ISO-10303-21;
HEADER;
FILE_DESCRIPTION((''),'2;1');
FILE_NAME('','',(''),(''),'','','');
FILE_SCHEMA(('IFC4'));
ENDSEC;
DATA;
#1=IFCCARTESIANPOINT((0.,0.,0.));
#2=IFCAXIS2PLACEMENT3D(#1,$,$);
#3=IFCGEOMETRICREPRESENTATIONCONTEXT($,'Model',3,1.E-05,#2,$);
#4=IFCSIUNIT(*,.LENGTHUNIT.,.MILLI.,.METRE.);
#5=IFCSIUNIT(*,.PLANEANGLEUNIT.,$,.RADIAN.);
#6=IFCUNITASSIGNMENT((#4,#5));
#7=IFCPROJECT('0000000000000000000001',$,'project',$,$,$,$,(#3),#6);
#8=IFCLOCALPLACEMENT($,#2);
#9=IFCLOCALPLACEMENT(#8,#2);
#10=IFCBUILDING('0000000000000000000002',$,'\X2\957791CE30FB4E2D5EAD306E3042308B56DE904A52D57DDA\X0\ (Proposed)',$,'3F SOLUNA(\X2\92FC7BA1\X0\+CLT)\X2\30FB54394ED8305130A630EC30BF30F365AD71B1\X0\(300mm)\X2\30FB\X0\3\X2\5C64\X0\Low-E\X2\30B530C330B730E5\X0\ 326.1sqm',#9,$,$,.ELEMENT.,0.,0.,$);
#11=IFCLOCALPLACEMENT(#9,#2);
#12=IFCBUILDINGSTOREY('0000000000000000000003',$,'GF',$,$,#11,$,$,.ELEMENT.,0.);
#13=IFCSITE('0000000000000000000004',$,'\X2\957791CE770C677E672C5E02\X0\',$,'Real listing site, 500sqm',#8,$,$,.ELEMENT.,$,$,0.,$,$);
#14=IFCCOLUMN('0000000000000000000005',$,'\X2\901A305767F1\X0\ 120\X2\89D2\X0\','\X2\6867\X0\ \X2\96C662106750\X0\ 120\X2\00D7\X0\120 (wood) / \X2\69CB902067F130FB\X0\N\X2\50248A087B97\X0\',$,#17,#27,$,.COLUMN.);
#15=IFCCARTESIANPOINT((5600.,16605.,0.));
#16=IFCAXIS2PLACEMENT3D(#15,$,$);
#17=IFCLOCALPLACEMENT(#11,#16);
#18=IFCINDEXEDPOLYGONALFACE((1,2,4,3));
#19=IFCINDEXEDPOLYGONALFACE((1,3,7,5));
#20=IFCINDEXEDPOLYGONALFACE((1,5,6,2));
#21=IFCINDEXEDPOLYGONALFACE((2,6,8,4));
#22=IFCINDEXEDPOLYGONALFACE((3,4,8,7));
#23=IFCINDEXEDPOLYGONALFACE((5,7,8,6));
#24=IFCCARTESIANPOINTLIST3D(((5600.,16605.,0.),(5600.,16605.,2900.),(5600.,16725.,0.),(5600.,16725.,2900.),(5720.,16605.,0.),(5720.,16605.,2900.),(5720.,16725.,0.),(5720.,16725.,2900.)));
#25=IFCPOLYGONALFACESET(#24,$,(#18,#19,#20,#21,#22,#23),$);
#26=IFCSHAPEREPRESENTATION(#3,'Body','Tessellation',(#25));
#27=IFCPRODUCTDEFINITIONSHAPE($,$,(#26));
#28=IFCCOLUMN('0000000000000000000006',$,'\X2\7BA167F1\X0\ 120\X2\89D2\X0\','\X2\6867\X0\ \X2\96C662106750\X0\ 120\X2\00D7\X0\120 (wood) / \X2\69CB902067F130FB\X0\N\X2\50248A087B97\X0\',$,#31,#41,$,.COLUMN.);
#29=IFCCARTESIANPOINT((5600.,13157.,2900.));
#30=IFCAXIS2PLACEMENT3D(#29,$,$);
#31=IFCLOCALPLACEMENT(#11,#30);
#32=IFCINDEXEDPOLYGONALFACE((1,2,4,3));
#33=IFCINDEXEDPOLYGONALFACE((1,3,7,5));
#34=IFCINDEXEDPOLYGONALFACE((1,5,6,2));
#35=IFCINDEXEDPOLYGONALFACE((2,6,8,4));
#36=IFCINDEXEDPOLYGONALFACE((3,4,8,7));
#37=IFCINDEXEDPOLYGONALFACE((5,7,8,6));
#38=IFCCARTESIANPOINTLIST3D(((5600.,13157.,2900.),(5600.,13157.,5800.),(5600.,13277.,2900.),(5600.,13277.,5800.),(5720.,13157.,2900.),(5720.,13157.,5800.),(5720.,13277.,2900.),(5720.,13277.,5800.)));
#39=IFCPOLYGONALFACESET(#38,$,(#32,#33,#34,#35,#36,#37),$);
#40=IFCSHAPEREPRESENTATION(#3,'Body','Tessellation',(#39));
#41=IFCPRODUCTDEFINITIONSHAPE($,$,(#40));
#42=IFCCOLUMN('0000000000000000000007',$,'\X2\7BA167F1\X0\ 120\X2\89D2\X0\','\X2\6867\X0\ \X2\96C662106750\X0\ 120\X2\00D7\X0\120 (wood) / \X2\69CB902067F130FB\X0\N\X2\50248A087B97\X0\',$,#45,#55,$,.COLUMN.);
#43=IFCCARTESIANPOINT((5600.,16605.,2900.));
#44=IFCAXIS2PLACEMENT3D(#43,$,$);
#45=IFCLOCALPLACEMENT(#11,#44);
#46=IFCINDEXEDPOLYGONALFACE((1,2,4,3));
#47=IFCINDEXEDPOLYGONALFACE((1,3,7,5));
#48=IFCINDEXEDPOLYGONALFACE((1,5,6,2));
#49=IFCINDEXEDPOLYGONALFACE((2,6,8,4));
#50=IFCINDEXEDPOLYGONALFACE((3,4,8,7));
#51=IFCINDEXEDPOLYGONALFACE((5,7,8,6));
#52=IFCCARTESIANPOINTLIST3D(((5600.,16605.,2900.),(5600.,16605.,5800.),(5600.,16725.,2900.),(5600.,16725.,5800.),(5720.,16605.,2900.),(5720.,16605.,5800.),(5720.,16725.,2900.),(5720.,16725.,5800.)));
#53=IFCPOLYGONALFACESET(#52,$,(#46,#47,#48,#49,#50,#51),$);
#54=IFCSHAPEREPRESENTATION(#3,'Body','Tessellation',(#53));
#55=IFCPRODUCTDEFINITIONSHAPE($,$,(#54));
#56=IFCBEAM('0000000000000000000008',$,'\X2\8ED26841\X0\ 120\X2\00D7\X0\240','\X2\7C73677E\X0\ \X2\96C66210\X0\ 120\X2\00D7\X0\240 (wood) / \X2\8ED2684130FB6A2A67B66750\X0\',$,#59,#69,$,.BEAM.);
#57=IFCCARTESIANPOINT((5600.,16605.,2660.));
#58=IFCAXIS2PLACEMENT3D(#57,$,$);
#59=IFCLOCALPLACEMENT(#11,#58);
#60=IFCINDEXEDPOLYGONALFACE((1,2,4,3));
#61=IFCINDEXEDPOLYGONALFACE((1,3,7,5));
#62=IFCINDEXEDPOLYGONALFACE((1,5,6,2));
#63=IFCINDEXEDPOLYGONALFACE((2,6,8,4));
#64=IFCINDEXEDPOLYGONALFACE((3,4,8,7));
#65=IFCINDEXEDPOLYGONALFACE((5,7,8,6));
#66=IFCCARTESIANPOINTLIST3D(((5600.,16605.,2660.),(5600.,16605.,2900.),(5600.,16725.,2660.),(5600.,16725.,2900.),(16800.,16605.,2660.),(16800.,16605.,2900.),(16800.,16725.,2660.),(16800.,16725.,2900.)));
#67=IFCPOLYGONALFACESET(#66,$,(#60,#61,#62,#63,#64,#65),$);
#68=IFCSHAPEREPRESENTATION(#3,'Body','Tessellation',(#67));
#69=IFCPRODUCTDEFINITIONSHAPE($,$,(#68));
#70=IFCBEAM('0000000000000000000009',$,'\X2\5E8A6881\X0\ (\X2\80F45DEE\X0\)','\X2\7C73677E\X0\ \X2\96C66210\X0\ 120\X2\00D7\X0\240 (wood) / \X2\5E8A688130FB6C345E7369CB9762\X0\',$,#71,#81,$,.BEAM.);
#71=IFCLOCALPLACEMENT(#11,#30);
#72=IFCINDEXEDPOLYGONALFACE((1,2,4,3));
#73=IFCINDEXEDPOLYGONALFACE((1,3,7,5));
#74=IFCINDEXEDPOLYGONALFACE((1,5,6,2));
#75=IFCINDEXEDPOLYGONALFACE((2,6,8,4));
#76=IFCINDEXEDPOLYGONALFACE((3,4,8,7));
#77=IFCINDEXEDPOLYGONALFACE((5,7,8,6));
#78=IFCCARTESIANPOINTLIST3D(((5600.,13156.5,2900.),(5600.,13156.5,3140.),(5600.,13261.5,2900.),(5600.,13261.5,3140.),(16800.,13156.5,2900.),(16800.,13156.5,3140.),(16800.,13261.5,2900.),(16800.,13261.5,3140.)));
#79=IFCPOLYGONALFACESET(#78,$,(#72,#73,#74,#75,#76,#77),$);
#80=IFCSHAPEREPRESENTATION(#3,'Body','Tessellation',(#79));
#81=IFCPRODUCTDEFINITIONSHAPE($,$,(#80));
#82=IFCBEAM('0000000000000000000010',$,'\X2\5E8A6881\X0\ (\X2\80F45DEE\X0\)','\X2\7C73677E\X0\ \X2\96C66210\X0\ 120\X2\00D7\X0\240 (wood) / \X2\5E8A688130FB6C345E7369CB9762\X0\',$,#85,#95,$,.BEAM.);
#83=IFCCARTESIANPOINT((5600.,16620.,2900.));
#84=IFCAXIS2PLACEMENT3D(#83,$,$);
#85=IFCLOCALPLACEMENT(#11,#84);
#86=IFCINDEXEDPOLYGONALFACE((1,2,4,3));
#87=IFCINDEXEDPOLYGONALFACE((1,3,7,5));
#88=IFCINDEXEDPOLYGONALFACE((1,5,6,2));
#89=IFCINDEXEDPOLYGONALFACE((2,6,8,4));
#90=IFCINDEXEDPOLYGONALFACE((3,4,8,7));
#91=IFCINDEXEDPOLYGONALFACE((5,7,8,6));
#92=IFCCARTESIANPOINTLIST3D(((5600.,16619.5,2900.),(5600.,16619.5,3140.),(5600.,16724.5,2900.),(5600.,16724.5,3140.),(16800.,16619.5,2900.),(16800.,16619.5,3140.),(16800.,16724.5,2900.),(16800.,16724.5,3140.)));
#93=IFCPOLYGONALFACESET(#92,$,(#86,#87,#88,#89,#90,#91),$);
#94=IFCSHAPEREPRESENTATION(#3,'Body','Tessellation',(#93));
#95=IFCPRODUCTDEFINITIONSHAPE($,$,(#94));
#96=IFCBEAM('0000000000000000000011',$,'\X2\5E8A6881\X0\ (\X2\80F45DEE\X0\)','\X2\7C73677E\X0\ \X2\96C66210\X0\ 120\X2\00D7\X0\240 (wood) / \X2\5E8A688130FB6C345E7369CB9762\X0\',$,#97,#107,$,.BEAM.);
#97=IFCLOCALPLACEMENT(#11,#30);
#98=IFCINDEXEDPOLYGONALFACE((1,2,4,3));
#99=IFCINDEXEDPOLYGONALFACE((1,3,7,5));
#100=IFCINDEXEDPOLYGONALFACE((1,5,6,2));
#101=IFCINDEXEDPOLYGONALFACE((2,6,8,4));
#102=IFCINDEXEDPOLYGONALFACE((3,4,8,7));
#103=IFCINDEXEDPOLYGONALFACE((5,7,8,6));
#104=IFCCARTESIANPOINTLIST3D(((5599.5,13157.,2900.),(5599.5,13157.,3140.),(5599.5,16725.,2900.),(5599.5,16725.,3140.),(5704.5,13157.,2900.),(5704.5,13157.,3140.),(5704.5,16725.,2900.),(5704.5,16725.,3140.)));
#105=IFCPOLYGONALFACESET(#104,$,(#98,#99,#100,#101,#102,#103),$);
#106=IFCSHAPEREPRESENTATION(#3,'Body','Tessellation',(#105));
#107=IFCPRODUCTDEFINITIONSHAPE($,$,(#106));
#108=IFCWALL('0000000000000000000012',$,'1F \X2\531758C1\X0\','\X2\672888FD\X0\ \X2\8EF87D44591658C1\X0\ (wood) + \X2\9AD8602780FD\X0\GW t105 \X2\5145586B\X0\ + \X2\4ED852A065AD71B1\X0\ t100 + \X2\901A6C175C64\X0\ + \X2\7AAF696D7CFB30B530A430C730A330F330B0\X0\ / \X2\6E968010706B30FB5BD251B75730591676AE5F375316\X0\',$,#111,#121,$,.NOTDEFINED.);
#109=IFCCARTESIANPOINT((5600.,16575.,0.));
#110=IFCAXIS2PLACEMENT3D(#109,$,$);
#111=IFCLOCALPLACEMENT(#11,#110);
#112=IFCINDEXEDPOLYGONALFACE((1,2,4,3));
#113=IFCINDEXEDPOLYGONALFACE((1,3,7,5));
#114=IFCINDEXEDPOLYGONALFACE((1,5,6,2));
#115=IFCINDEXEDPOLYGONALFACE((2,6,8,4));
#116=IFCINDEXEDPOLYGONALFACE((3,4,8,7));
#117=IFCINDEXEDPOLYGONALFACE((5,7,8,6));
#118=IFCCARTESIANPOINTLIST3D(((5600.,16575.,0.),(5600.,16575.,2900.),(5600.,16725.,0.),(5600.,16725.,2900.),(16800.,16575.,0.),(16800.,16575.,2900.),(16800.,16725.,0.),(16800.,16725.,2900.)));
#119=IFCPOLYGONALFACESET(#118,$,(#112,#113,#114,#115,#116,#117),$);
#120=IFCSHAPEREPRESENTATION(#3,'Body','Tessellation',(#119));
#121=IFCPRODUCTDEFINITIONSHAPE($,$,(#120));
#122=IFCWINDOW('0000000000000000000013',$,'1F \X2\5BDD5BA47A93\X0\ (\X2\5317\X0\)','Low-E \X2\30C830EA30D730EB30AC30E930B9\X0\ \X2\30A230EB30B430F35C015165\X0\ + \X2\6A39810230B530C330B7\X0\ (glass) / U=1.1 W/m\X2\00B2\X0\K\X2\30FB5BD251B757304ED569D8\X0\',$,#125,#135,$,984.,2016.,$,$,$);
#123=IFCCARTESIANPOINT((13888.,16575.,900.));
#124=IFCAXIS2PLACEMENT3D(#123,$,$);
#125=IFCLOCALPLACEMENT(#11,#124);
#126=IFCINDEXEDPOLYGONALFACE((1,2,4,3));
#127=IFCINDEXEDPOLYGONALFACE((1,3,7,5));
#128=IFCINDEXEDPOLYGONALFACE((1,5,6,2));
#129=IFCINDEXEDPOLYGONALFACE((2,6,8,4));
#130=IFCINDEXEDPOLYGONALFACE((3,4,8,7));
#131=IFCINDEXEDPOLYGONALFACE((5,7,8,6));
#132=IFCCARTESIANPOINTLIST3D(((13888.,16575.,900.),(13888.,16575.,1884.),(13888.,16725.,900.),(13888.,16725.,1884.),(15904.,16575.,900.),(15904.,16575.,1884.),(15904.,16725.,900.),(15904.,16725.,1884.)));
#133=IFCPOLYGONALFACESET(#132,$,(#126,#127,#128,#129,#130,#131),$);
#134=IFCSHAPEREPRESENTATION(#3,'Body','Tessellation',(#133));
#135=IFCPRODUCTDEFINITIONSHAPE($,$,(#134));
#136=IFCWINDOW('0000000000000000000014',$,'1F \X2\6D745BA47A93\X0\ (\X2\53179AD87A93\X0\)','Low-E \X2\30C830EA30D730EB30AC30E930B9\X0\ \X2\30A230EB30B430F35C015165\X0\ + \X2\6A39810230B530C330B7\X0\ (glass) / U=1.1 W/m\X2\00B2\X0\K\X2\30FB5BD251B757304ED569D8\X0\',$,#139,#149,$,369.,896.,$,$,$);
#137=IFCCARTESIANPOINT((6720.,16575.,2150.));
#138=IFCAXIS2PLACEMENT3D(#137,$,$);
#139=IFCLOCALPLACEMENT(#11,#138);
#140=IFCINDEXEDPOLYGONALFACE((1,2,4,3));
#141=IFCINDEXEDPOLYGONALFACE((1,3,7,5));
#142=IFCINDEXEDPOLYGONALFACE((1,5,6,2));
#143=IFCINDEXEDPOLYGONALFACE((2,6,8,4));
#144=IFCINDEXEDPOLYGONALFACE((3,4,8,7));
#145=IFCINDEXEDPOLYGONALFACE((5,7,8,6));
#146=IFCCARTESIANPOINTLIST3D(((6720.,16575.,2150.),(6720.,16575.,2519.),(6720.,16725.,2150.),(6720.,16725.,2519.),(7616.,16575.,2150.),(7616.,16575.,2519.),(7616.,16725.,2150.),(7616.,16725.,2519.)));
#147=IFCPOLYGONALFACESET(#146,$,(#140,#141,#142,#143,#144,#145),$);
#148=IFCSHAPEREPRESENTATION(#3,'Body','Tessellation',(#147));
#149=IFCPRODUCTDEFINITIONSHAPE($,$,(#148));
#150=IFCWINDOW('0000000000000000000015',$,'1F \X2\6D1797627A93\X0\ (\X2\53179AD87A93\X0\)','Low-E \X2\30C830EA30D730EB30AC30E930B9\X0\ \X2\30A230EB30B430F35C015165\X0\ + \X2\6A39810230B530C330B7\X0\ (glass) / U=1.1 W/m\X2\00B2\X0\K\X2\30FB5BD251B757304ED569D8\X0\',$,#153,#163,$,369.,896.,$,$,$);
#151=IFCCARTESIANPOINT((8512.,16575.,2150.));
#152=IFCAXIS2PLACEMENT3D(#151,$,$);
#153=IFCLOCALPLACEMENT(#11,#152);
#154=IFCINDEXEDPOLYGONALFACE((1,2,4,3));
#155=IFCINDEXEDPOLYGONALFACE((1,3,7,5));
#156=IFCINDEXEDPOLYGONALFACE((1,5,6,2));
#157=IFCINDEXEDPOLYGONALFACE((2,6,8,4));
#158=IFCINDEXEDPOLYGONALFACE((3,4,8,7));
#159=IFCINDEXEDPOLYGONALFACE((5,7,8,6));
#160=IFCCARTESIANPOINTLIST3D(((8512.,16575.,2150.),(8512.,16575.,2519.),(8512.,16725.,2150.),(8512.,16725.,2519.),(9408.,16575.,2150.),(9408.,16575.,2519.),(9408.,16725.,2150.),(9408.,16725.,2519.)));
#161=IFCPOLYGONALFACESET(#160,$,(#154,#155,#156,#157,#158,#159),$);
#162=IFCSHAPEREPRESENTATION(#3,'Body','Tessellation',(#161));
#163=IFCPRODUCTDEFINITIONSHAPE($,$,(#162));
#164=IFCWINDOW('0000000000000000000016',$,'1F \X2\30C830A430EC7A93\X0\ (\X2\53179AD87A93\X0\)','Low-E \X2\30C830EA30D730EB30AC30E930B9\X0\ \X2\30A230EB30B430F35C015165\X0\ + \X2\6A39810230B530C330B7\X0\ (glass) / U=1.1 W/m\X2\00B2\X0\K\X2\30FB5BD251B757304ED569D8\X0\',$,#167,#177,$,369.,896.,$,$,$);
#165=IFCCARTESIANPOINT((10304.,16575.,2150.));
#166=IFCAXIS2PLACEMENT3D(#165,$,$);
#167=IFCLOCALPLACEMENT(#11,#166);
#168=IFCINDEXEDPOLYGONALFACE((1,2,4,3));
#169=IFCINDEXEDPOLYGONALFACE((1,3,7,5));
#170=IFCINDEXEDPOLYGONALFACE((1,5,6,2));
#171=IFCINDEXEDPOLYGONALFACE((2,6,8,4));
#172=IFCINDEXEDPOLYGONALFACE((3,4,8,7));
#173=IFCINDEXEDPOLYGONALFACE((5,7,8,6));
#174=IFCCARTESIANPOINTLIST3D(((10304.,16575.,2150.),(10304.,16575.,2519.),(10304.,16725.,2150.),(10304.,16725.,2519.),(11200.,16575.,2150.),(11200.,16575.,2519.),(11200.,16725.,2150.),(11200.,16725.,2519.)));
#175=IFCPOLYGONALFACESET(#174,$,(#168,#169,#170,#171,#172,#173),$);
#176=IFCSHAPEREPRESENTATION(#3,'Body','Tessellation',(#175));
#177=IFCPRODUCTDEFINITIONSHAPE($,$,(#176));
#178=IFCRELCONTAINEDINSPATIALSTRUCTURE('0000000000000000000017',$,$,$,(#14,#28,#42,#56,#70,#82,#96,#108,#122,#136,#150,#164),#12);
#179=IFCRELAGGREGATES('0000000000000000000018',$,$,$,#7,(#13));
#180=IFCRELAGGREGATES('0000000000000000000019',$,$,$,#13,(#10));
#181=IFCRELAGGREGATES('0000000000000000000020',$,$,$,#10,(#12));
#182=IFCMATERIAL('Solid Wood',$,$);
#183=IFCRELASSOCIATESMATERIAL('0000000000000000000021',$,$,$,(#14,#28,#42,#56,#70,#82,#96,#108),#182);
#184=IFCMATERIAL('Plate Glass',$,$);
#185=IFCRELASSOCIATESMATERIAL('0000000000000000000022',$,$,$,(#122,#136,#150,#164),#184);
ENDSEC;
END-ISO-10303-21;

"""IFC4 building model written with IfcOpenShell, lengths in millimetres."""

from ifc_helpers import new_model, si_unit, frame, frame_2d, origin, place, context, project, spatial, rectangle, extrude, material, element, fill, save


model = new_model("IFC4")

# Units and contexts
model_context = context("Model", 3, precision=1e-05, world=origin())
ifc_project = project(units=[si_unit("LENGTHUNIT", "METRE", prefix="MILLI"), si_unit("PLANEANGLEUNIT", "RADIAN")], contexts=[model_context])

# Site, building, storey
site_placement = place(None, origin())
site = spatial("IfcSite", under=ifc_project, at=site_placement, Name="長野県松本市", ObjectType="Real listing site, 500sqm", CompositionType="ELEMENT", RefElevation=0.0)
building_placement = place(site_placement, origin())
building = spatial("IfcBuilding", under=site, at=building_placement, Name="長野・中庭のある回遊動線 (Proposed)", ObjectType="3F SOLUNA(鋼管+CLT)・吹付けウレタン断熱(300mm)・3層Low-Eサッシュ 326.1sqm", CompositionType="ELEMENT", ElevationOfRefHeight=0.0, ElevationOfTerrain=0.0)
storey_placement = place(building_placement, origin())
storey = spatial("IfcBuildingStorey", under=building, at=storey_placement, Name="GF", CompositionType="ELEMENT", Elevation=0.0)

# Columns
ifc_material_1 = material(Name="Solid Wood")
column_1_placement = place(storey_placement, frame((5600.0, 16605.0, 0.0)))
element("IfcColumn", 1, at=column_1_placement, inside=storey, material=ifc_material_1, Name="通し柱 120角", Description="桧 集成材 120×120 (wood) / 構造柱・N値計算", PredefinedType="COLUMN", context=model_context, shape_type="SweptSolid", body=[
    extrude(rectangle(XDim=120.0, YDim=120.0, at=frame_2d((60.0, 60.0))), frame((5600.0, 16605.0, 0.0)), (0.0, 0.0, 1.0), 2900.0),
])
column_2_placement = place(storey_placement, frame((5600.0, 13157.0, 2900.0)))
element("IfcColumn", 2, at=column_2_placement, inside=storey, material=ifc_material_1, Name="管柱 120角", Description="桧 集成材 120×120 (wood) / 構造柱・N値計算", PredefinedType="COLUMN", context=model_context, shape_type="SweptSolid", body=[
    extrude(rectangle(XDim=120.0, YDim=120.0, at=frame_2d((60.0, 60.0))), frame((5600.0, 13157.0, 2900.0)), (0.0, 0.0, 1.0), 2900.0),
])
column_3_placement = place(storey_placement, frame((5600.0, 16605.0, 2900.0)))
element("IfcColumn", 3, at=column_3_placement, inside=storey, material=ifc_material_1, Name="管柱 120角", Description="桧 集成材 120×120 (wood) / 構造柱・N値計算", PredefinedType="COLUMN", context=model_context, shape_type="SweptSolid", body=[
    extrude(rectangle(XDim=120.0, YDim=120.0, at=frame_2d((60.0, 60.0))), frame((5600.0, 16605.0, 2900.0)), (0.0, 0.0, 1.0), 2900.0),
])

# Beams
beam_1_placement = place(storey_placement, frame((5600.0, 16605.0, 2660.0)))
element("IfcBeam", 4, at=beam_1_placement, inside=storey, material=ifc_material_1, Name="軒桁 120×240", Description="米松 集成 120×240 (wood) / 軒桁・横架材", PredefinedType="BEAM", context=model_context, shape_type="SweptSolid", body=[
    extrude(rectangle(XDim=11200.0, YDim=120.0, at=frame_2d((5600.0, 60.0))), frame((5600.0, 16605.0, 2660.0)), (0.0, 0.0, 1.0), 240.0),
])
beam_2_placement = place(storey_placement, frame((5600.0, 13157.0, 2900.0)))
element("IfcBeam", 5, at=beam_2_placement, inside=storey, material=ifc_material_1, Name="床梁 (胴差)", Description="米松 集成 120×240 (wood) / 床梁・水平構面", PredefinedType="BEAM", context=model_context, shape_type="SweptSolid", body=[
    extrude(rectangle(XDim=11200.0, YDim=105.0, at=frame_2d((5600.0, 52.0))), frame((5600.0, 13157.0, 2900.0)), (0.0, 0.0, 1.0), 240.0),
])
beam_3_placement = place(storey_placement, frame((5600.0, 16620.0, 2900.0)))
element("IfcBeam", 6, at=beam_3_placement, inside=storey, material=ifc_material_1, Name="床梁 (胴差)", Description="米松 集成 120×240 (wood) / 床梁・水平構面", PredefinedType="BEAM", context=model_context, shape_type="SweptSolid", body=[
    extrude(rectangle(XDim=11200.0, YDim=105.0, at=frame_2d((5600.0, 52.0))), frame((5600.0, 16620.0, 2900.0)), (0.0, 0.0, 1.0), 240.0),
])
beam_4_placement = place(storey_placement, frame((5600.0, 13157.0, 2900.0)))
element("IfcBeam", 7, at=beam_4_placement, inside=storey, material=ifc_material_1, Name="床梁 (胴差)", Description="米松 集成 120×240 (wood) / 床梁・水平構面", PredefinedType="BEAM", context=model_context, shape_type="SweptSolid", body=[
    extrude(rectangle(XDim=105.0, YDim=3568.0, at=frame_2d((52.0, 1784.0))), frame((5600.0, 13157.0, 2900.0)), (0.0, 0.0, 1.0), 240.0),
])

# Wall, openings, windows
wall_1_placement = place(storey_placement, frame((5600.0, 16575.0, 0.0)))
wall_1 = element("IfcWall", 8, at=wall_1_placement, inside=storey, material=ifc_material_1, Name="1F 北壁", Description="木製 軸組外壁 (wood) + 高性能GW t105 充填 + 付加断熱 t100 + 通気層 + 窯業系サイディング / 準耐火・寒冷地外皮強化", PredefinedType="NOTDEFINED", context=model_context, shape_type="SweptSolid", body=[
    extrude(rectangle(XDim=11200.0, YDim=150.0, at=frame_2d((5600.0, 75.0))), frame((5600.0, 16575.0, 0.0)), (0.0, 0.0, 1.0), 2900.0),
])
opening_1_placement = place(storey_placement, frame((13888.0, 16575.0, 900.0)))
opening_1 = element("IfcOpeningElement", 9, at=opening_1_placement, cuts=wall_1, PredefinedType="NOTDEFINED", context=model_context, shape_type="SweptSolid", body=[
    extrude(rectangle(XDim=2016.0, YDim=150.0, at=frame_2d((1008.0, 75.0))), frame((13888.0, 16575.0, 900.0)), (0.0, 0.0, 1.0), 984.0),
])
opening_2_placement = place(storey_placement, frame((6720.0, 16575.0, 2150.0)))
opening_2 = element("IfcOpeningElement", 10, at=opening_2_placement, cuts=wall_1, PredefinedType="NOTDEFINED", context=model_context, shape_type="SweptSolid", body=[
    extrude(rectangle(XDim=896.0, YDim=150.0, at=frame_2d((448.0, 75.0))), frame((6720.0, 16575.0, 2150.0)), (0.0, 0.0, 1.0), 369.0),
])
opening_3_placement = place(storey_placement, frame((8512.0, 16575.0, 2150.0)))
opening_3 = element("IfcOpeningElement", 11, at=opening_3_placement, cuts=wall_1, PredefinedType="NOTDEFINED", context=model_context, shape_type="SweptSolid", body=[
    extrude(rectangle(XDim=896.0, YDim=150.0, at=frame_2d((448.0, 75.0))), frame((8512.0, 16575.0, 2150.0)), (0.0, 0.0, 1.0), 369.0),
])
opening_4_placement = place(storey_placement, frame((10304.0, 16575.0, 2150.0)))
opening_4 = element("IfcOpeningElement", 12, at=opening_4_placement, cuts=wall_1, PredefinedType="NOTDEFINED", context=model_context, shape_type="SweptSolid", body=[
    extrude(rectangle(XDim=896.0, YDim=150.0, at=frame_2d((448.0, 75.0))), frame((10304.0, 16575.0, 2150.0)), (0.0, 0.0, 1.0), 369.0),
])
ifc_material_2 = material(Name="Plate Glass")
window_1_placement = place(storey_placement, frame((13888.0, 16575.0, 900.0)))
window_1 = element("IfcWindow", 13, at=window_1_placement, inside=storey, material=ifc_material_2, Name="1F 寝室窓 (北)", Description="Low-E トリプルガラス アルゴン封入 + 樹脂サッシ (glass) / U=1.1 W/m²K・寒冷地仕様", OverallHeight=984.0, OverallWidth=2016.0, context=model_context, shape_type="SweptSolid", body=[
    extrude(rectangle(XDim=2016.0, YDim=150.0, at=frame_2d((1008.0, 75.0))), frame((13888.0, 16575.0, 900.0)), (0.0, 0.0, 1.0), 984.0),
])
fill(opening_1, window_1)
window_2_placement = place(storey_placement, frame((6720.0, 16575.0, 2150.0)))
window_2 = element("IfcWindow", 14, at=window_2_placement, inside=storey, material=ifc_material_2, Name="1F 浴室窓 (北高窓)", Description="Low-E トリプルガラス アルゴン封入 + 樹脂サッシ (glass) / U=1.1 W/m²K・寒冷地仕様", OverallHeight=369.0, OverallWidth=896.0, context=model_context, shape_type="SweptSolid", body=[
    extrude(rectangle(XDim=896.0, YDim=150.0, at=frame_2d((448.0, 75.0))), frame((6720.0, 16575.0, 2150.0)), (0.0, 0.0, 1.0), 369.0),
])
fill(opening_2, window_2)
window_3_placement = place(storey_placement, frame((8512.0, 16575.0, 2150.0)))
window_3 = element("IfcWindow", 15, at=window_3_placement, inside=storey, material=ifc_material_2, Name="1F 洗面窓 (北高窓)", Description="Low-E トリプルガラス アルゴン封入 + 樹脂サッシ (glass) / U=1.1 W/m²K・寒冷地仕様", OverallHeight=369.0, OverallWidth=896.0, context=model_context, shape_type="SweptSolid", body=[
    extrude(rectangle(XDim=896.0, YDim=150.0, at=frame_2d((448.0, 75.0))), frame((8512.0, 16575.0, 2150.0)), (0.0, 0.0, 1.0), 369.0),
])
fill(opening_3, window_3)
window_4_placement = place(storey_placement, frame((10304.0, 16575.0, 2150.0)))
window_4 = element("IfcWindow", 16, at=window_4_placement, inside=storey, material=ifc_material_2, Name="1F トイレ窓 (北高窓)", Description="Low-E トリプルガラス アルゴン封入 + 樹脂サッシ (glass) / U=1.1 W/m²K・寒冷地仕様", OverallHeight=369.0, OverallWidth=896.0, context=model_context, shape_type="SweptSolid", body=[
    extrude(rectangle(XDim=896.0, YDim=150.0, at=frame_2d((448.0, 75.0))), frame((10304.0, 16575.0, 2150.0)), (0.0, 0.0, 1.0), 369.0),
])
fill(opening_4, window_4)

save(model, "model.ifc")
